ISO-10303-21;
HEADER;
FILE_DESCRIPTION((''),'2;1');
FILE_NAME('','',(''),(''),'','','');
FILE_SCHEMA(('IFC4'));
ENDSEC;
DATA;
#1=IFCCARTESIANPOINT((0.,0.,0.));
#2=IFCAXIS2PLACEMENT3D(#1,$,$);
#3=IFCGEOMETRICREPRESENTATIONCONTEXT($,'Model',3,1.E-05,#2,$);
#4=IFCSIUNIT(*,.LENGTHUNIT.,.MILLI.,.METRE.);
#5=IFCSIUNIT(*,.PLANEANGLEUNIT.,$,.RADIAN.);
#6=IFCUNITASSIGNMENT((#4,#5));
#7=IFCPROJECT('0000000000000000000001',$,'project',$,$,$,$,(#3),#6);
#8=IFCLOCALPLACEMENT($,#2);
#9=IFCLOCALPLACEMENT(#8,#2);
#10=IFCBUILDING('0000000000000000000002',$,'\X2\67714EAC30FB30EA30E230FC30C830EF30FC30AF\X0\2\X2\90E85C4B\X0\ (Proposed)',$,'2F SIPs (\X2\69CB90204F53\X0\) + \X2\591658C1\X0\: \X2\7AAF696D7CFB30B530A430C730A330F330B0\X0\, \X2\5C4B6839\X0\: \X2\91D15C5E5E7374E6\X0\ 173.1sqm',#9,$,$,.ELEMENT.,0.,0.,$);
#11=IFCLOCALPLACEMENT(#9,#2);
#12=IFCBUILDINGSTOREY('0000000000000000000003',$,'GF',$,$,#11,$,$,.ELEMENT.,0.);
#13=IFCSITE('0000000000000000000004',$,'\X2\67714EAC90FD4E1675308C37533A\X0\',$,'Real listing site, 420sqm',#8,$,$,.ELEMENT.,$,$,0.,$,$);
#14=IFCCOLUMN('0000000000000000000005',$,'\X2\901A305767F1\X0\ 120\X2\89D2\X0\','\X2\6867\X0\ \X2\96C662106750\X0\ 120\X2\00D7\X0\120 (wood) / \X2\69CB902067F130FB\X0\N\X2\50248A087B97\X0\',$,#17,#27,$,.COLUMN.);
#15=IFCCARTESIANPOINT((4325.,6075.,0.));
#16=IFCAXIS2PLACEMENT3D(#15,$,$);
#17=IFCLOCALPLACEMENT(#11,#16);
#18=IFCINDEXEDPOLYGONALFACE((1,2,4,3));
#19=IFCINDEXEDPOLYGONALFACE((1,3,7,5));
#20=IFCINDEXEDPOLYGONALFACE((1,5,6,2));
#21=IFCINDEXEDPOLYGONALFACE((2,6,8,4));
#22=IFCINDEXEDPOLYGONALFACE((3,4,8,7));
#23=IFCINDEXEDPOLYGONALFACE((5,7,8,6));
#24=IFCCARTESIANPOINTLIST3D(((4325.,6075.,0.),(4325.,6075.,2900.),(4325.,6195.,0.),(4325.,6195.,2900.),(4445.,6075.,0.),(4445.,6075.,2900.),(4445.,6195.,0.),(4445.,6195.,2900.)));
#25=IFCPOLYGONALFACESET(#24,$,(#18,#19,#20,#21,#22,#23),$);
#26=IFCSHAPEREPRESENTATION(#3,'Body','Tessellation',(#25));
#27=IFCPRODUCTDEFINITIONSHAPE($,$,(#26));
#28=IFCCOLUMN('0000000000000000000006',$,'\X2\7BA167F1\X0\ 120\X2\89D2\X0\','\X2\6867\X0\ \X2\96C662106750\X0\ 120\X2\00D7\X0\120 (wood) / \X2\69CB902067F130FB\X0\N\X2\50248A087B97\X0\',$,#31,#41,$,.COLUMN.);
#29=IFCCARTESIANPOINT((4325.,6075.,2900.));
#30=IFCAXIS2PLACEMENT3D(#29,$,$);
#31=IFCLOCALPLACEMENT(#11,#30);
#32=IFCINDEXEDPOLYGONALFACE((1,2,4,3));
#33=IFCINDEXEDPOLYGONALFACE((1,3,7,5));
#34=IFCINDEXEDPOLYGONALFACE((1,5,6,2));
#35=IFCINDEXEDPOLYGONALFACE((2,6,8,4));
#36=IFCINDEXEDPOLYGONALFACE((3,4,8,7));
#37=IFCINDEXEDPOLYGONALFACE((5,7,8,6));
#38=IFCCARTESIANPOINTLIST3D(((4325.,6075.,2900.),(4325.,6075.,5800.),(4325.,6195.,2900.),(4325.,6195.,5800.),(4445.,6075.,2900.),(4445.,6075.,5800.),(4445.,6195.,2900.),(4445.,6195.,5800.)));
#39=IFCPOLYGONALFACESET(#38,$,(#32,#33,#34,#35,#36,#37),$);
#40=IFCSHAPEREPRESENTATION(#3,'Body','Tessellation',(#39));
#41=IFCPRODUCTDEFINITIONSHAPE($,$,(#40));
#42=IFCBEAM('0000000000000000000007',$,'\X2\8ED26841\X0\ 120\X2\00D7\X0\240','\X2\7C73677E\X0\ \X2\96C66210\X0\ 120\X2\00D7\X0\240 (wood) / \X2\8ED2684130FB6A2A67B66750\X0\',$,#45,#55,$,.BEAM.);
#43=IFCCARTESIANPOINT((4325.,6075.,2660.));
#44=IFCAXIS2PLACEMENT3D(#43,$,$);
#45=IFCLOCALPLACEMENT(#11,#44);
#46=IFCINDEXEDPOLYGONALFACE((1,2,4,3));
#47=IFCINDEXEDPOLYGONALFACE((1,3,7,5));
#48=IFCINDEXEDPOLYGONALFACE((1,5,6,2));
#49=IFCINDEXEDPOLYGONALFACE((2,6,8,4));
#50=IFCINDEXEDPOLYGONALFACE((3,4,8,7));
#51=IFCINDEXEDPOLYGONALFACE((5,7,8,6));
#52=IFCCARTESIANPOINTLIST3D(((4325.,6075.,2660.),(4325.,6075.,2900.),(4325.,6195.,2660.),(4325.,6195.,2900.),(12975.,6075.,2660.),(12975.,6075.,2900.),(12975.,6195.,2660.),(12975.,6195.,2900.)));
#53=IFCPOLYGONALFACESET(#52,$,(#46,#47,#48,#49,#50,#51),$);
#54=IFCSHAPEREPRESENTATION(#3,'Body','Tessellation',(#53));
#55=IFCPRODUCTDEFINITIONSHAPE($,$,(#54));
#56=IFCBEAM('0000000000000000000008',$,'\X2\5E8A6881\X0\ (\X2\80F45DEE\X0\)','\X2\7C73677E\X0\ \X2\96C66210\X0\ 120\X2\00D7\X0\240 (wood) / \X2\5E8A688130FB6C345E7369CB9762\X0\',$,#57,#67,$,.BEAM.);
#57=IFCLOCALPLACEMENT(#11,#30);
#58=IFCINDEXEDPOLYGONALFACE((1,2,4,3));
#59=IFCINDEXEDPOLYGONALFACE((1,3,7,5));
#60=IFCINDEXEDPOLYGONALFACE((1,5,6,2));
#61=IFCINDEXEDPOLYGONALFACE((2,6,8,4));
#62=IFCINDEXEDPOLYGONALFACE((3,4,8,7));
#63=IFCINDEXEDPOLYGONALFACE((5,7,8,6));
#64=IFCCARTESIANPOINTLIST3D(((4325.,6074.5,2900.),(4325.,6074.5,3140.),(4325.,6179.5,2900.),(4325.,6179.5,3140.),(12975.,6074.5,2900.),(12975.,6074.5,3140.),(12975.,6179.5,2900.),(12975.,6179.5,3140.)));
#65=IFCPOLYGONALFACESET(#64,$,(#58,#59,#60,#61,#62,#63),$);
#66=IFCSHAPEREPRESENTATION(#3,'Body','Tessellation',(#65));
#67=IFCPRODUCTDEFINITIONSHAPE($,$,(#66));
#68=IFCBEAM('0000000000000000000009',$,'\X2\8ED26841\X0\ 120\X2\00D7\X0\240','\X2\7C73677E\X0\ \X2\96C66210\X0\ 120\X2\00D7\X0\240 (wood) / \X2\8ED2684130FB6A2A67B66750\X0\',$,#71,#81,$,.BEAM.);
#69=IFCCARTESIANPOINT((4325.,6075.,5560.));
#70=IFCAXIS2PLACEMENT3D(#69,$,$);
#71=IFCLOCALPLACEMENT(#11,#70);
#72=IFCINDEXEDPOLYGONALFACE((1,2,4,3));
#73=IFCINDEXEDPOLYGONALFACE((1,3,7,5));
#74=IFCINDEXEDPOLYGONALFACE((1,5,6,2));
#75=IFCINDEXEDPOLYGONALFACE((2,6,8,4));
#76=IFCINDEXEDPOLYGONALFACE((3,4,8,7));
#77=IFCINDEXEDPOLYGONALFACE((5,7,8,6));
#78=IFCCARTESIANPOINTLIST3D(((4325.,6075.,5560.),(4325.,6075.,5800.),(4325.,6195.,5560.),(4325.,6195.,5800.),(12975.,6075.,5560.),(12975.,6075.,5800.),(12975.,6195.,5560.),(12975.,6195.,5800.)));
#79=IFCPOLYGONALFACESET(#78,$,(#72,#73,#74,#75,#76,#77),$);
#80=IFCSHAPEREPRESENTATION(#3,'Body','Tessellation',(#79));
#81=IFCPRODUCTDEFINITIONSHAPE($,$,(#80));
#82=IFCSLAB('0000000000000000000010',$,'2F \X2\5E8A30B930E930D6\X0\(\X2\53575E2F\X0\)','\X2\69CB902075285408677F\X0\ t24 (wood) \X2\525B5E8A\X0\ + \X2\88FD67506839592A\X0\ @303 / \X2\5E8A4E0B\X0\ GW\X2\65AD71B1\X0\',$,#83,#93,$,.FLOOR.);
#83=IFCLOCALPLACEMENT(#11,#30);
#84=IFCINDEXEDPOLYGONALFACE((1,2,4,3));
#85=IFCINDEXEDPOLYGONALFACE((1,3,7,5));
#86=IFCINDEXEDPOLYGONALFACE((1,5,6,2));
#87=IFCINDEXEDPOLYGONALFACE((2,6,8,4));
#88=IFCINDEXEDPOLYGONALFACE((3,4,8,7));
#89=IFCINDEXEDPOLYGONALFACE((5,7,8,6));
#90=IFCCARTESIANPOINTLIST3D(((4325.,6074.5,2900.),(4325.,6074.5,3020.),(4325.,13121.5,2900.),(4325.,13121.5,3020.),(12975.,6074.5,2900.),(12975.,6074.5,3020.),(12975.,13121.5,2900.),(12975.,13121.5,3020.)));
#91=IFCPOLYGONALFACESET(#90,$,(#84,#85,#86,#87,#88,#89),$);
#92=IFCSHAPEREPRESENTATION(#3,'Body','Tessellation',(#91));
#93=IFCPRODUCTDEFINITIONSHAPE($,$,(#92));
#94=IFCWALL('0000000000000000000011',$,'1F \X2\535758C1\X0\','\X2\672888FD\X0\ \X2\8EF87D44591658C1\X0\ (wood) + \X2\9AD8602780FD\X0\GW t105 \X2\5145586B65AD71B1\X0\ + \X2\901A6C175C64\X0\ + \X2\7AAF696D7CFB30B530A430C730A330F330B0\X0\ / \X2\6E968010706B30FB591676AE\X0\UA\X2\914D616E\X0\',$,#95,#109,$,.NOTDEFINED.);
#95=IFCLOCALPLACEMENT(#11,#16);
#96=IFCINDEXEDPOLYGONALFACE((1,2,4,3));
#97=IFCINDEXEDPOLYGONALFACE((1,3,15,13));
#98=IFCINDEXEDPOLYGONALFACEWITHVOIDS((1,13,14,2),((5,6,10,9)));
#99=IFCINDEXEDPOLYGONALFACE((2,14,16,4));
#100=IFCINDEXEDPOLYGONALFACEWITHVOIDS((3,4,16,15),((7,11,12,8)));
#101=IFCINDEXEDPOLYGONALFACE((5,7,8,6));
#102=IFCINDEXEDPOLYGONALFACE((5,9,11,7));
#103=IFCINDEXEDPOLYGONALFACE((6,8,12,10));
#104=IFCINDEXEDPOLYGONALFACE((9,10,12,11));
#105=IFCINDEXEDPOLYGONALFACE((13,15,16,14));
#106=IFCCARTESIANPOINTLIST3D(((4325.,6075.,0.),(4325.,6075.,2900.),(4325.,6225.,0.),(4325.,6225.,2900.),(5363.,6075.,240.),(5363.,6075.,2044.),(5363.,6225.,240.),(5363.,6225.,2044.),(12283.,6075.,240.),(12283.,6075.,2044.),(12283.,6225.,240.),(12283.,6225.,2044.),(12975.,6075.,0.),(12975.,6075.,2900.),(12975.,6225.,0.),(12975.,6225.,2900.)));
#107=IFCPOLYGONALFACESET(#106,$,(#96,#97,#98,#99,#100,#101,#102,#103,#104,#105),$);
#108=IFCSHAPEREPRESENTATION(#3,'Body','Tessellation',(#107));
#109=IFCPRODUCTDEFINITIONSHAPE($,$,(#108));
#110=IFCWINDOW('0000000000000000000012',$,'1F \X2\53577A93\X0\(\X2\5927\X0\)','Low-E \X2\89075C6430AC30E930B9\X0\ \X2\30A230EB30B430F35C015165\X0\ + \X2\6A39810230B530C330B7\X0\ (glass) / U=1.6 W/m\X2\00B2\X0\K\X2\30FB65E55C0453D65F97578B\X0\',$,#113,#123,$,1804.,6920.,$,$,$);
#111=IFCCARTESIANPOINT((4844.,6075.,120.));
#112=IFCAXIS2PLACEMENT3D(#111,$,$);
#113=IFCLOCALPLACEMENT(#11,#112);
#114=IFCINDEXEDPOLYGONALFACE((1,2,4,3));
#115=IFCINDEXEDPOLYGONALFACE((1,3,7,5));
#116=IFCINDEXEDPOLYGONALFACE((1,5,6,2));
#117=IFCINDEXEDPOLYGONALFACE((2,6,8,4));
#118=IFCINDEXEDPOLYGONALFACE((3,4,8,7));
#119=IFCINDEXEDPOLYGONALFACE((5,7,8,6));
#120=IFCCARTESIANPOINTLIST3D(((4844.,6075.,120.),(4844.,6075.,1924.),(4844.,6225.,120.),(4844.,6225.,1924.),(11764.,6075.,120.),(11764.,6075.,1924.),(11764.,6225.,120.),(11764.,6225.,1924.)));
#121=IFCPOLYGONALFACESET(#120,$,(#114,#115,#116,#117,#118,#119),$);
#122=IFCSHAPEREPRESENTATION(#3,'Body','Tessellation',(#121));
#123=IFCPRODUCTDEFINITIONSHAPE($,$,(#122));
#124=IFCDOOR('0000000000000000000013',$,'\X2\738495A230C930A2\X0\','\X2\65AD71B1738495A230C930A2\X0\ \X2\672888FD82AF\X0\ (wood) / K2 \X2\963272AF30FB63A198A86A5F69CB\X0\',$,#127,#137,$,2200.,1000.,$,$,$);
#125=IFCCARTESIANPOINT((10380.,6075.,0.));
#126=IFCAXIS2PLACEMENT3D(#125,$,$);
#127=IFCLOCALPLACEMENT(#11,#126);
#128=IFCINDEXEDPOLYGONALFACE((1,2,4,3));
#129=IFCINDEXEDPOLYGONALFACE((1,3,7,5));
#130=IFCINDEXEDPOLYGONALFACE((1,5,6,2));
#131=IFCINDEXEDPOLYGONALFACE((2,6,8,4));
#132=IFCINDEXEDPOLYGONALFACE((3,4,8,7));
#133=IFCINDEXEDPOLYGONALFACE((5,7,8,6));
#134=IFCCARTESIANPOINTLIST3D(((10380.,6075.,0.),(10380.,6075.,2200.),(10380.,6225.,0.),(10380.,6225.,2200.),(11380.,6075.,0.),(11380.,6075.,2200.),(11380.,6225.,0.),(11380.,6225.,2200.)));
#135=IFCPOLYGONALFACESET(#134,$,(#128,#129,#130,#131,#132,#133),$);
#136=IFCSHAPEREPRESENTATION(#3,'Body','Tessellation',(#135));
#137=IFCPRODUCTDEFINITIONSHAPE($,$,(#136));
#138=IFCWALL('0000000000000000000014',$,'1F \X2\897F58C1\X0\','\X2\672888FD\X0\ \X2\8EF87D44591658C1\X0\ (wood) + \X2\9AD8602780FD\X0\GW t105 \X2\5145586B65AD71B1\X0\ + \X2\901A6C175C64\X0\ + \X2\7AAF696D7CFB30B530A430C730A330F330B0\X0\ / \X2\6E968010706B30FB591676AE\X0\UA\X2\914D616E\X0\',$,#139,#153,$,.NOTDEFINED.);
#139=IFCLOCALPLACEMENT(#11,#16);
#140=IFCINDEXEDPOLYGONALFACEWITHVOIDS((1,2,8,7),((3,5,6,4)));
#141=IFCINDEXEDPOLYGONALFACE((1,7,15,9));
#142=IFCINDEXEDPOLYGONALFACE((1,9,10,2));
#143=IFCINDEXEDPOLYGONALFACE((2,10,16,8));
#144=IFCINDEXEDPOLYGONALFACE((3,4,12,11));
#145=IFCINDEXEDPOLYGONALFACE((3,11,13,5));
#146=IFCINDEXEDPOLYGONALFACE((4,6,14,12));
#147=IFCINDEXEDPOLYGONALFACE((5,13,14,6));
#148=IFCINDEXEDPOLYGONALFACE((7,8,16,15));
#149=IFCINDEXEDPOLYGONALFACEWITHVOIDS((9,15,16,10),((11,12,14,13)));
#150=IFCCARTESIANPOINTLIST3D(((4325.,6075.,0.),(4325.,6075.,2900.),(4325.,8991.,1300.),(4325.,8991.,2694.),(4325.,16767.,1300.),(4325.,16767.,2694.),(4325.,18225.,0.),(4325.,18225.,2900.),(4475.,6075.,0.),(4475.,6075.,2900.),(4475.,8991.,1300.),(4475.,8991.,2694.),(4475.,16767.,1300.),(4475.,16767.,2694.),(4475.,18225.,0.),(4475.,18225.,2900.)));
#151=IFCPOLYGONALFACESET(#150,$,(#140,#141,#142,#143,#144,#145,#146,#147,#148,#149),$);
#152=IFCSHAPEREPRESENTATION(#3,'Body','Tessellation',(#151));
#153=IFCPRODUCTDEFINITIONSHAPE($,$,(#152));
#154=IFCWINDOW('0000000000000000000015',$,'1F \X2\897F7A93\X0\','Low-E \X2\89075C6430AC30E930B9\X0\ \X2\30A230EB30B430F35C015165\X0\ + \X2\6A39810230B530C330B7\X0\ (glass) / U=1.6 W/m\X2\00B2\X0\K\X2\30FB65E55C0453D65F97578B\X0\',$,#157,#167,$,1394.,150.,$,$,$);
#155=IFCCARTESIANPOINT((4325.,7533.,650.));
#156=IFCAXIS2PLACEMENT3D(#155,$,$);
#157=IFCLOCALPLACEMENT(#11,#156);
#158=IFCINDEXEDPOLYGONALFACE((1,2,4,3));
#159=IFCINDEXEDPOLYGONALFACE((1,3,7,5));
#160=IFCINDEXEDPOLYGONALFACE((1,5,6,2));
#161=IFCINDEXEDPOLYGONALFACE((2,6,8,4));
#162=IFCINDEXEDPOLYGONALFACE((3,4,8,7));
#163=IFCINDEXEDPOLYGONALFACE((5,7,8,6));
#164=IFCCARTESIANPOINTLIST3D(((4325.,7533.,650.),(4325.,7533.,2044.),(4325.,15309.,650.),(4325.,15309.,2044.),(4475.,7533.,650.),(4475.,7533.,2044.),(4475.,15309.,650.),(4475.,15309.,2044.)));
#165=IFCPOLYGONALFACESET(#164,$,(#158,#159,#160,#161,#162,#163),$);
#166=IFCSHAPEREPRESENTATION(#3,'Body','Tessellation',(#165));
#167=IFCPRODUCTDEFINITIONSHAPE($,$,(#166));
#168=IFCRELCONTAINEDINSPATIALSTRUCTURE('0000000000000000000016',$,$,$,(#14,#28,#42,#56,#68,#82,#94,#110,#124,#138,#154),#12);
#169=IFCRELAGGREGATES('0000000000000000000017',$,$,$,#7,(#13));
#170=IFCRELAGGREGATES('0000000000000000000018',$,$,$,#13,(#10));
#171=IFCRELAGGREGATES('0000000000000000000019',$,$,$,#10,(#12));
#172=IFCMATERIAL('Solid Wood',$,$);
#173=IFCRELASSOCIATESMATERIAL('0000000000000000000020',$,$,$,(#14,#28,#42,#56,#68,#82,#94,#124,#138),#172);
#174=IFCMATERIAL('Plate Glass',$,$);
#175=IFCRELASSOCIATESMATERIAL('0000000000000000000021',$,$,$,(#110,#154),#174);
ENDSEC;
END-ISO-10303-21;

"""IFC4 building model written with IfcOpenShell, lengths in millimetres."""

from ifc_helpers import new_model, si_unit, frame, frame_2d, origin, place, context, project, spatial, rectangle, extrude, material, element, fill, save


model = new_model("IFC4")

# Units and contexts
model_context = context("Model", 3, precision=1e-05, world=origin())
ifc_project = project(units=[si_unit("LENGTHUNIT", "METRE", prefix="MILLI"), si_unit("PLANEANGLEUNIT", "RADIAN")], contexts=[model_context])

# Site, building, storey
site_placement = place(None, origin())
site = spatial("IfcSite", under=ifc_project, at=site_placement, Name="東京都世田谷区", ObjectType="Real listing site, 420sqm", CompositionType="ELEMENT", RefElevation=0.0)
building_placement = place(site_placement, origin())
building = spatial("IfcBuilding", under=site, at=building_placement, Name="東京・リモートワーク2部屋 (Proposed)", ObjectType="2F SIPs (構造体) + 外壁: 窯業系サイディング, 屋根: 金属平瓦 173.1sqm", CompositionType="ELEMENT", ElevationOfRefHeight=0.0, ElevationOfTerrain=0.0)
storey_placement = place(building_placement, origin())
storey = spatial("IfcBuildingStorey", under=building, at=storey_placement, Name="GF", CompositionType="ELEMENT", Elevation=0.0)

# Columns
ifc_material_1 = material(Name="Solid Wood")
column_1_placement = place(storey_placement, frame((4325.0, 6075.0, 0.0)))
element("IfcColumn", 1, at=column_1_placement, inside=storey, material=ifc_material_1, Name="通し柱 120角", Description="桧 集成材 120×120 (wood) / 構造柱・N値計算", PredefinedType="COLUMN", context=model_context, shape_type="SweptSolid", body=[
    extrude(rectangle(XDim=120.0, YDim=120.0, at=frame_2d((60.0, 60.0))), frame((4325.0, 6075.0, 0.0)), (0.0, 0.0, 1.0), 2900.0),
])
column_2_placement = place(storey_placement, frame((4325.0, 6075.0, 2900.0)))
element("IfcColumn", 2, at=column_2_placement, inside=storey, material=ifc_material_1, Name="管柱 120角", Description="桧 集成材 120×120 (wood) / 構造柱・N値計算", PredefinedType="COLUMN", context=model_context, shape_type="SweptSolid", body=[
    extrude(rectangle(XDim=120.0, YDim=120.0, at=frame_2d((60.0, 60.0))), frame((4325.0, 6075.0, 2900.0)), (0.0, 0.0, 1.0), 2900.0),
])

# Beams
beam_1_placement = place(storey_placement, frame((4325.0, 6075.0, 2660.0)))
element("IfcBeam", 3, at=beam_1_placement, inside=storey, material=ifc_material_1, Name="軒桁 120×240", Description="米松 集成 120×240 (wood) / 軒桁・横架材", PredefinedType="BEAM", context=model_context, shape_type="SweptSolid", body=[
    extrude(rectangle(XDim=8650.0, YDim=120.0, at=frame_2d((4325.0, 60.0))), frame((4325.0, 6075.0, 2660.0)), (0.0, 0.0, 1.0), 240.0),
])
beam_2_placement = place(storey_placement, frame((4325.0, 6075.0, 2900.0)))
element("IfcBeam", 4, at=beam_2_placement, inside=storey, material=ifc_material_1, Name="床梁 (胴差)", Description="米松 集成 120×240 (wood) / 床梁・水平構面", PredefinedType="BEAM", context=model_context, shape_type="SweptSolid", body=[
    extrude(rectangle(XDim=8650.0, YDim=105.0, at=frame_2d((4325.0, 52.0))), frame((4325.0, 6075.0, 2900.0)), (0.0, 0.0, 1.0), 240.0),
])
beam_3_placement = place(storey_placement, frame((4325.0, 6075.0, 5560.0)))
element("IfcBeam", 5, at=beam_3_placement, inside=storey, material=ifc_material_1, Name="軒桁 120×240", Description="米松 集成 120×240 (wood) / 軒桁・横架材", PredefinedType="BEAM", context=model_context, shape_type="SweptSolid", body=[
    extrude(rectangle(XDim=8650.0, YDim=120.0, at=frame_2d((4325.0, 60.0))), frame((4325.0, 6075.0, 5560.0)), (0.0, 0.0, 1.0), 240.0),
])

# Slab
slab_1_placement = place(storey_placement, frame((4325.0, 6075.0, 2900.0)))
element("IfcSlab", 6, at=slab_1_placement, inside=storey, material=ifc_material_1, Name="2F 床スラブ(南帯)", Description="構造用合板 t24 (wood) 剛床 + 製材根太 @303 / 床下 GW断熱", PredefinedType="FLOOR", context=model_context, shape_type="SweptSolid", body=[
    extrude(rectangle(XDim=8650.0, YDim=7047.0, at=frame_2d((4325.0, 3523.0))), frame((4325.0, 6075.0, 2900.0)), (0.0, 0.0, 1.0), 120.0),
])

# Wall, openings, window, door
wall_1_placement = place(storey_placement, frame((4325.0, 6075.0, 0.0)))
wall_1 = element("IfcWall", 7, at=wall_1_placement, inside=storey, material=ifc_material_1, Name="1F 南壁", Description="木製 軸組外壁 (wood) + 高性能GW t105 充填断熱 + 通気層 + 窯業系サイディング / 準耐火・外皮UA配慮", PredefinedType="NOTDEFINED", context=model_context, shape_type="SweptSolid", body=[
    extrude(rectangle(XDim=8650.0, YDim=150.0, at=frame_2d((4325.0, 75.0))), frame((4325.0, 6075.0, 0.0)), (0.0, 0.0, 1.0), 2900.0),
])
opening_1_placement = place(storey_placement, frame((4844.0, 6075.0, 120.0)))
opening_1 = element("IfcOpeningElement", 8, at=opening_1_placement, cuts=wall_1, PredefinedType="NOTDEFINED", context=model_context, shape_type="SweptSolid", body=[
    extrude(rectangle(XDim=6920.0, YDim=150.0, at=frame_2d((3460.0, 75.0))), frame((4844.0, 6075.0, 120.0)), (0.0, 0.0, 1.0), 1804.0),
])
opening_2_placement = place(storey_placement, frame((10380.0, 6075.0, 0.0)))
opening_2 = element("IfcOpeningElement", 9, at=opening_2_placement, cuts=wall_1, PredefinedType="NOTDEFINED", context=model_context, shape_type="SweptSolid", body=[
    extrude(rectangle(XDim=1000.0, YDim=150.0, at=frame_2d((500.0, 75.0))), frame((10380.0, 6075.0, 0.0)), (0.0, 0.0, 1.0), 2200.0),
])
ifc_material_2 = material(Name="Plate Glass")
window_1_placement = place(storey_placement, frame((4844.0, 6075.0, 120.0)))
window_1 = element("IfcWindow", 10, at=window_1_placement, inside=storey, material=ifc_material_2, Name="1F 南窓(大)", Description="Low-E 複層ガラス アルゴン封入 + 樹脂サッシ (glass) / U=1.6 W/m²K・日射取得型", OverallHeight=1804.0, OverallWidth=6920.0, context=model_context, shape_type="SweptSolid", body=[
    extrude(rectangle(XDim=6920.0, YDim=150.0, at=frame_2d((3460.0, 75.0))), frame((4844.0, 6075.0, 120.0)), (0.0, 0.0, 1.0), 1804.0),
])
fill(opening_1, window_1)
door_placement = place(storey_placement, frame((10380.0, 6075.0, 0.0)))
door = element("IfcDoor", 11, at=door_placement, inside=storey, material=ifc_material_1, Name="玄関ドア", Description="断熱玄関ドア 木製芯 (wood) / K2 防犯・採風機構", OverallHeight=2200.0, OverallWidth=1000.0, context=model_context, shape_type="SweptSolid", body=[
    extrude(rectangle(XDim=1000.0, YDim=150.0, at=frame_2d((500.0, 75.0))), frame((10380.0, 6075.0, 0.0)), (0.0, 0.0, 1.0), 2200.0),
])
fill(opening_2, door)

# Wall, opening, window
wall_2_placement = place(storey_placement, frame((4325.0, 6075.0, 0.0)))
wall_2 = element("IfcWall", 12, at=wall_2_placement, inside=storey, material=ifc_material_1, Name="1F 西壁", Description="木製 軸組外壁 (wood) + 高性能GW t105 充填断熱 + 通気層 + 窯業系サイディング / 準耐火・外皮UA配慮", PredefinedType="NOTDEFINED", context=model_context, shape_type="SweptSolid", body=[
    extrude(rectangle(XDim=150.0, YDim=12150.0, at=frame_2d((75.0, 6075.0))), frame((4325.0, 6075.0, 0.0)), (0.0, 0.0, 1.0), 2900.0),
])
opening_3_placement = place(storey_placement, frame((4325.0, 7533.0, 650.0)))
opening_3 = element("IfcOpeningElement", 13, at=opening_3_placement, cuts=wall_2, PredefinedType="NOTDEFINED", context=model_context, shape_type="SweptSolid", body=[
    extrude(rectangle(XDim=150.0, YDim=7776.0, at=frame_2d((75.0, 3888.0))), frame((4325.0, 7533.0, 650.0)), (0.0, 0.0, 1.0), 1394.0),
])
window_2_placement = place(storey_placement, frame((4325.0, 7533.0, 650.0)))
window_2 = element("IfcWindow", 14, at=window_2_placement, inside=storey, material=ifc_material_2, Name="1F 西窓", Description="Low-E 複層ガラス アルゴン封入 + 樹脂サッシ (glass) / U=1.6 W/m²K・日射取得型", OverallHeight=1394.0, OverallWidth=150.0, context=model_context, shape_type="SweptSolid", body=[
    extrude(rectangle(XDim=150.0, YDim=7776.0, at=frame_2d((75.0, 3888.0))), frame((4325.0, 7533.0, 650.0)), (0.0, 0.0, 1.0), 1394.0),
])
fill(opening_3, window_2)

save(model, "model.ifc")
